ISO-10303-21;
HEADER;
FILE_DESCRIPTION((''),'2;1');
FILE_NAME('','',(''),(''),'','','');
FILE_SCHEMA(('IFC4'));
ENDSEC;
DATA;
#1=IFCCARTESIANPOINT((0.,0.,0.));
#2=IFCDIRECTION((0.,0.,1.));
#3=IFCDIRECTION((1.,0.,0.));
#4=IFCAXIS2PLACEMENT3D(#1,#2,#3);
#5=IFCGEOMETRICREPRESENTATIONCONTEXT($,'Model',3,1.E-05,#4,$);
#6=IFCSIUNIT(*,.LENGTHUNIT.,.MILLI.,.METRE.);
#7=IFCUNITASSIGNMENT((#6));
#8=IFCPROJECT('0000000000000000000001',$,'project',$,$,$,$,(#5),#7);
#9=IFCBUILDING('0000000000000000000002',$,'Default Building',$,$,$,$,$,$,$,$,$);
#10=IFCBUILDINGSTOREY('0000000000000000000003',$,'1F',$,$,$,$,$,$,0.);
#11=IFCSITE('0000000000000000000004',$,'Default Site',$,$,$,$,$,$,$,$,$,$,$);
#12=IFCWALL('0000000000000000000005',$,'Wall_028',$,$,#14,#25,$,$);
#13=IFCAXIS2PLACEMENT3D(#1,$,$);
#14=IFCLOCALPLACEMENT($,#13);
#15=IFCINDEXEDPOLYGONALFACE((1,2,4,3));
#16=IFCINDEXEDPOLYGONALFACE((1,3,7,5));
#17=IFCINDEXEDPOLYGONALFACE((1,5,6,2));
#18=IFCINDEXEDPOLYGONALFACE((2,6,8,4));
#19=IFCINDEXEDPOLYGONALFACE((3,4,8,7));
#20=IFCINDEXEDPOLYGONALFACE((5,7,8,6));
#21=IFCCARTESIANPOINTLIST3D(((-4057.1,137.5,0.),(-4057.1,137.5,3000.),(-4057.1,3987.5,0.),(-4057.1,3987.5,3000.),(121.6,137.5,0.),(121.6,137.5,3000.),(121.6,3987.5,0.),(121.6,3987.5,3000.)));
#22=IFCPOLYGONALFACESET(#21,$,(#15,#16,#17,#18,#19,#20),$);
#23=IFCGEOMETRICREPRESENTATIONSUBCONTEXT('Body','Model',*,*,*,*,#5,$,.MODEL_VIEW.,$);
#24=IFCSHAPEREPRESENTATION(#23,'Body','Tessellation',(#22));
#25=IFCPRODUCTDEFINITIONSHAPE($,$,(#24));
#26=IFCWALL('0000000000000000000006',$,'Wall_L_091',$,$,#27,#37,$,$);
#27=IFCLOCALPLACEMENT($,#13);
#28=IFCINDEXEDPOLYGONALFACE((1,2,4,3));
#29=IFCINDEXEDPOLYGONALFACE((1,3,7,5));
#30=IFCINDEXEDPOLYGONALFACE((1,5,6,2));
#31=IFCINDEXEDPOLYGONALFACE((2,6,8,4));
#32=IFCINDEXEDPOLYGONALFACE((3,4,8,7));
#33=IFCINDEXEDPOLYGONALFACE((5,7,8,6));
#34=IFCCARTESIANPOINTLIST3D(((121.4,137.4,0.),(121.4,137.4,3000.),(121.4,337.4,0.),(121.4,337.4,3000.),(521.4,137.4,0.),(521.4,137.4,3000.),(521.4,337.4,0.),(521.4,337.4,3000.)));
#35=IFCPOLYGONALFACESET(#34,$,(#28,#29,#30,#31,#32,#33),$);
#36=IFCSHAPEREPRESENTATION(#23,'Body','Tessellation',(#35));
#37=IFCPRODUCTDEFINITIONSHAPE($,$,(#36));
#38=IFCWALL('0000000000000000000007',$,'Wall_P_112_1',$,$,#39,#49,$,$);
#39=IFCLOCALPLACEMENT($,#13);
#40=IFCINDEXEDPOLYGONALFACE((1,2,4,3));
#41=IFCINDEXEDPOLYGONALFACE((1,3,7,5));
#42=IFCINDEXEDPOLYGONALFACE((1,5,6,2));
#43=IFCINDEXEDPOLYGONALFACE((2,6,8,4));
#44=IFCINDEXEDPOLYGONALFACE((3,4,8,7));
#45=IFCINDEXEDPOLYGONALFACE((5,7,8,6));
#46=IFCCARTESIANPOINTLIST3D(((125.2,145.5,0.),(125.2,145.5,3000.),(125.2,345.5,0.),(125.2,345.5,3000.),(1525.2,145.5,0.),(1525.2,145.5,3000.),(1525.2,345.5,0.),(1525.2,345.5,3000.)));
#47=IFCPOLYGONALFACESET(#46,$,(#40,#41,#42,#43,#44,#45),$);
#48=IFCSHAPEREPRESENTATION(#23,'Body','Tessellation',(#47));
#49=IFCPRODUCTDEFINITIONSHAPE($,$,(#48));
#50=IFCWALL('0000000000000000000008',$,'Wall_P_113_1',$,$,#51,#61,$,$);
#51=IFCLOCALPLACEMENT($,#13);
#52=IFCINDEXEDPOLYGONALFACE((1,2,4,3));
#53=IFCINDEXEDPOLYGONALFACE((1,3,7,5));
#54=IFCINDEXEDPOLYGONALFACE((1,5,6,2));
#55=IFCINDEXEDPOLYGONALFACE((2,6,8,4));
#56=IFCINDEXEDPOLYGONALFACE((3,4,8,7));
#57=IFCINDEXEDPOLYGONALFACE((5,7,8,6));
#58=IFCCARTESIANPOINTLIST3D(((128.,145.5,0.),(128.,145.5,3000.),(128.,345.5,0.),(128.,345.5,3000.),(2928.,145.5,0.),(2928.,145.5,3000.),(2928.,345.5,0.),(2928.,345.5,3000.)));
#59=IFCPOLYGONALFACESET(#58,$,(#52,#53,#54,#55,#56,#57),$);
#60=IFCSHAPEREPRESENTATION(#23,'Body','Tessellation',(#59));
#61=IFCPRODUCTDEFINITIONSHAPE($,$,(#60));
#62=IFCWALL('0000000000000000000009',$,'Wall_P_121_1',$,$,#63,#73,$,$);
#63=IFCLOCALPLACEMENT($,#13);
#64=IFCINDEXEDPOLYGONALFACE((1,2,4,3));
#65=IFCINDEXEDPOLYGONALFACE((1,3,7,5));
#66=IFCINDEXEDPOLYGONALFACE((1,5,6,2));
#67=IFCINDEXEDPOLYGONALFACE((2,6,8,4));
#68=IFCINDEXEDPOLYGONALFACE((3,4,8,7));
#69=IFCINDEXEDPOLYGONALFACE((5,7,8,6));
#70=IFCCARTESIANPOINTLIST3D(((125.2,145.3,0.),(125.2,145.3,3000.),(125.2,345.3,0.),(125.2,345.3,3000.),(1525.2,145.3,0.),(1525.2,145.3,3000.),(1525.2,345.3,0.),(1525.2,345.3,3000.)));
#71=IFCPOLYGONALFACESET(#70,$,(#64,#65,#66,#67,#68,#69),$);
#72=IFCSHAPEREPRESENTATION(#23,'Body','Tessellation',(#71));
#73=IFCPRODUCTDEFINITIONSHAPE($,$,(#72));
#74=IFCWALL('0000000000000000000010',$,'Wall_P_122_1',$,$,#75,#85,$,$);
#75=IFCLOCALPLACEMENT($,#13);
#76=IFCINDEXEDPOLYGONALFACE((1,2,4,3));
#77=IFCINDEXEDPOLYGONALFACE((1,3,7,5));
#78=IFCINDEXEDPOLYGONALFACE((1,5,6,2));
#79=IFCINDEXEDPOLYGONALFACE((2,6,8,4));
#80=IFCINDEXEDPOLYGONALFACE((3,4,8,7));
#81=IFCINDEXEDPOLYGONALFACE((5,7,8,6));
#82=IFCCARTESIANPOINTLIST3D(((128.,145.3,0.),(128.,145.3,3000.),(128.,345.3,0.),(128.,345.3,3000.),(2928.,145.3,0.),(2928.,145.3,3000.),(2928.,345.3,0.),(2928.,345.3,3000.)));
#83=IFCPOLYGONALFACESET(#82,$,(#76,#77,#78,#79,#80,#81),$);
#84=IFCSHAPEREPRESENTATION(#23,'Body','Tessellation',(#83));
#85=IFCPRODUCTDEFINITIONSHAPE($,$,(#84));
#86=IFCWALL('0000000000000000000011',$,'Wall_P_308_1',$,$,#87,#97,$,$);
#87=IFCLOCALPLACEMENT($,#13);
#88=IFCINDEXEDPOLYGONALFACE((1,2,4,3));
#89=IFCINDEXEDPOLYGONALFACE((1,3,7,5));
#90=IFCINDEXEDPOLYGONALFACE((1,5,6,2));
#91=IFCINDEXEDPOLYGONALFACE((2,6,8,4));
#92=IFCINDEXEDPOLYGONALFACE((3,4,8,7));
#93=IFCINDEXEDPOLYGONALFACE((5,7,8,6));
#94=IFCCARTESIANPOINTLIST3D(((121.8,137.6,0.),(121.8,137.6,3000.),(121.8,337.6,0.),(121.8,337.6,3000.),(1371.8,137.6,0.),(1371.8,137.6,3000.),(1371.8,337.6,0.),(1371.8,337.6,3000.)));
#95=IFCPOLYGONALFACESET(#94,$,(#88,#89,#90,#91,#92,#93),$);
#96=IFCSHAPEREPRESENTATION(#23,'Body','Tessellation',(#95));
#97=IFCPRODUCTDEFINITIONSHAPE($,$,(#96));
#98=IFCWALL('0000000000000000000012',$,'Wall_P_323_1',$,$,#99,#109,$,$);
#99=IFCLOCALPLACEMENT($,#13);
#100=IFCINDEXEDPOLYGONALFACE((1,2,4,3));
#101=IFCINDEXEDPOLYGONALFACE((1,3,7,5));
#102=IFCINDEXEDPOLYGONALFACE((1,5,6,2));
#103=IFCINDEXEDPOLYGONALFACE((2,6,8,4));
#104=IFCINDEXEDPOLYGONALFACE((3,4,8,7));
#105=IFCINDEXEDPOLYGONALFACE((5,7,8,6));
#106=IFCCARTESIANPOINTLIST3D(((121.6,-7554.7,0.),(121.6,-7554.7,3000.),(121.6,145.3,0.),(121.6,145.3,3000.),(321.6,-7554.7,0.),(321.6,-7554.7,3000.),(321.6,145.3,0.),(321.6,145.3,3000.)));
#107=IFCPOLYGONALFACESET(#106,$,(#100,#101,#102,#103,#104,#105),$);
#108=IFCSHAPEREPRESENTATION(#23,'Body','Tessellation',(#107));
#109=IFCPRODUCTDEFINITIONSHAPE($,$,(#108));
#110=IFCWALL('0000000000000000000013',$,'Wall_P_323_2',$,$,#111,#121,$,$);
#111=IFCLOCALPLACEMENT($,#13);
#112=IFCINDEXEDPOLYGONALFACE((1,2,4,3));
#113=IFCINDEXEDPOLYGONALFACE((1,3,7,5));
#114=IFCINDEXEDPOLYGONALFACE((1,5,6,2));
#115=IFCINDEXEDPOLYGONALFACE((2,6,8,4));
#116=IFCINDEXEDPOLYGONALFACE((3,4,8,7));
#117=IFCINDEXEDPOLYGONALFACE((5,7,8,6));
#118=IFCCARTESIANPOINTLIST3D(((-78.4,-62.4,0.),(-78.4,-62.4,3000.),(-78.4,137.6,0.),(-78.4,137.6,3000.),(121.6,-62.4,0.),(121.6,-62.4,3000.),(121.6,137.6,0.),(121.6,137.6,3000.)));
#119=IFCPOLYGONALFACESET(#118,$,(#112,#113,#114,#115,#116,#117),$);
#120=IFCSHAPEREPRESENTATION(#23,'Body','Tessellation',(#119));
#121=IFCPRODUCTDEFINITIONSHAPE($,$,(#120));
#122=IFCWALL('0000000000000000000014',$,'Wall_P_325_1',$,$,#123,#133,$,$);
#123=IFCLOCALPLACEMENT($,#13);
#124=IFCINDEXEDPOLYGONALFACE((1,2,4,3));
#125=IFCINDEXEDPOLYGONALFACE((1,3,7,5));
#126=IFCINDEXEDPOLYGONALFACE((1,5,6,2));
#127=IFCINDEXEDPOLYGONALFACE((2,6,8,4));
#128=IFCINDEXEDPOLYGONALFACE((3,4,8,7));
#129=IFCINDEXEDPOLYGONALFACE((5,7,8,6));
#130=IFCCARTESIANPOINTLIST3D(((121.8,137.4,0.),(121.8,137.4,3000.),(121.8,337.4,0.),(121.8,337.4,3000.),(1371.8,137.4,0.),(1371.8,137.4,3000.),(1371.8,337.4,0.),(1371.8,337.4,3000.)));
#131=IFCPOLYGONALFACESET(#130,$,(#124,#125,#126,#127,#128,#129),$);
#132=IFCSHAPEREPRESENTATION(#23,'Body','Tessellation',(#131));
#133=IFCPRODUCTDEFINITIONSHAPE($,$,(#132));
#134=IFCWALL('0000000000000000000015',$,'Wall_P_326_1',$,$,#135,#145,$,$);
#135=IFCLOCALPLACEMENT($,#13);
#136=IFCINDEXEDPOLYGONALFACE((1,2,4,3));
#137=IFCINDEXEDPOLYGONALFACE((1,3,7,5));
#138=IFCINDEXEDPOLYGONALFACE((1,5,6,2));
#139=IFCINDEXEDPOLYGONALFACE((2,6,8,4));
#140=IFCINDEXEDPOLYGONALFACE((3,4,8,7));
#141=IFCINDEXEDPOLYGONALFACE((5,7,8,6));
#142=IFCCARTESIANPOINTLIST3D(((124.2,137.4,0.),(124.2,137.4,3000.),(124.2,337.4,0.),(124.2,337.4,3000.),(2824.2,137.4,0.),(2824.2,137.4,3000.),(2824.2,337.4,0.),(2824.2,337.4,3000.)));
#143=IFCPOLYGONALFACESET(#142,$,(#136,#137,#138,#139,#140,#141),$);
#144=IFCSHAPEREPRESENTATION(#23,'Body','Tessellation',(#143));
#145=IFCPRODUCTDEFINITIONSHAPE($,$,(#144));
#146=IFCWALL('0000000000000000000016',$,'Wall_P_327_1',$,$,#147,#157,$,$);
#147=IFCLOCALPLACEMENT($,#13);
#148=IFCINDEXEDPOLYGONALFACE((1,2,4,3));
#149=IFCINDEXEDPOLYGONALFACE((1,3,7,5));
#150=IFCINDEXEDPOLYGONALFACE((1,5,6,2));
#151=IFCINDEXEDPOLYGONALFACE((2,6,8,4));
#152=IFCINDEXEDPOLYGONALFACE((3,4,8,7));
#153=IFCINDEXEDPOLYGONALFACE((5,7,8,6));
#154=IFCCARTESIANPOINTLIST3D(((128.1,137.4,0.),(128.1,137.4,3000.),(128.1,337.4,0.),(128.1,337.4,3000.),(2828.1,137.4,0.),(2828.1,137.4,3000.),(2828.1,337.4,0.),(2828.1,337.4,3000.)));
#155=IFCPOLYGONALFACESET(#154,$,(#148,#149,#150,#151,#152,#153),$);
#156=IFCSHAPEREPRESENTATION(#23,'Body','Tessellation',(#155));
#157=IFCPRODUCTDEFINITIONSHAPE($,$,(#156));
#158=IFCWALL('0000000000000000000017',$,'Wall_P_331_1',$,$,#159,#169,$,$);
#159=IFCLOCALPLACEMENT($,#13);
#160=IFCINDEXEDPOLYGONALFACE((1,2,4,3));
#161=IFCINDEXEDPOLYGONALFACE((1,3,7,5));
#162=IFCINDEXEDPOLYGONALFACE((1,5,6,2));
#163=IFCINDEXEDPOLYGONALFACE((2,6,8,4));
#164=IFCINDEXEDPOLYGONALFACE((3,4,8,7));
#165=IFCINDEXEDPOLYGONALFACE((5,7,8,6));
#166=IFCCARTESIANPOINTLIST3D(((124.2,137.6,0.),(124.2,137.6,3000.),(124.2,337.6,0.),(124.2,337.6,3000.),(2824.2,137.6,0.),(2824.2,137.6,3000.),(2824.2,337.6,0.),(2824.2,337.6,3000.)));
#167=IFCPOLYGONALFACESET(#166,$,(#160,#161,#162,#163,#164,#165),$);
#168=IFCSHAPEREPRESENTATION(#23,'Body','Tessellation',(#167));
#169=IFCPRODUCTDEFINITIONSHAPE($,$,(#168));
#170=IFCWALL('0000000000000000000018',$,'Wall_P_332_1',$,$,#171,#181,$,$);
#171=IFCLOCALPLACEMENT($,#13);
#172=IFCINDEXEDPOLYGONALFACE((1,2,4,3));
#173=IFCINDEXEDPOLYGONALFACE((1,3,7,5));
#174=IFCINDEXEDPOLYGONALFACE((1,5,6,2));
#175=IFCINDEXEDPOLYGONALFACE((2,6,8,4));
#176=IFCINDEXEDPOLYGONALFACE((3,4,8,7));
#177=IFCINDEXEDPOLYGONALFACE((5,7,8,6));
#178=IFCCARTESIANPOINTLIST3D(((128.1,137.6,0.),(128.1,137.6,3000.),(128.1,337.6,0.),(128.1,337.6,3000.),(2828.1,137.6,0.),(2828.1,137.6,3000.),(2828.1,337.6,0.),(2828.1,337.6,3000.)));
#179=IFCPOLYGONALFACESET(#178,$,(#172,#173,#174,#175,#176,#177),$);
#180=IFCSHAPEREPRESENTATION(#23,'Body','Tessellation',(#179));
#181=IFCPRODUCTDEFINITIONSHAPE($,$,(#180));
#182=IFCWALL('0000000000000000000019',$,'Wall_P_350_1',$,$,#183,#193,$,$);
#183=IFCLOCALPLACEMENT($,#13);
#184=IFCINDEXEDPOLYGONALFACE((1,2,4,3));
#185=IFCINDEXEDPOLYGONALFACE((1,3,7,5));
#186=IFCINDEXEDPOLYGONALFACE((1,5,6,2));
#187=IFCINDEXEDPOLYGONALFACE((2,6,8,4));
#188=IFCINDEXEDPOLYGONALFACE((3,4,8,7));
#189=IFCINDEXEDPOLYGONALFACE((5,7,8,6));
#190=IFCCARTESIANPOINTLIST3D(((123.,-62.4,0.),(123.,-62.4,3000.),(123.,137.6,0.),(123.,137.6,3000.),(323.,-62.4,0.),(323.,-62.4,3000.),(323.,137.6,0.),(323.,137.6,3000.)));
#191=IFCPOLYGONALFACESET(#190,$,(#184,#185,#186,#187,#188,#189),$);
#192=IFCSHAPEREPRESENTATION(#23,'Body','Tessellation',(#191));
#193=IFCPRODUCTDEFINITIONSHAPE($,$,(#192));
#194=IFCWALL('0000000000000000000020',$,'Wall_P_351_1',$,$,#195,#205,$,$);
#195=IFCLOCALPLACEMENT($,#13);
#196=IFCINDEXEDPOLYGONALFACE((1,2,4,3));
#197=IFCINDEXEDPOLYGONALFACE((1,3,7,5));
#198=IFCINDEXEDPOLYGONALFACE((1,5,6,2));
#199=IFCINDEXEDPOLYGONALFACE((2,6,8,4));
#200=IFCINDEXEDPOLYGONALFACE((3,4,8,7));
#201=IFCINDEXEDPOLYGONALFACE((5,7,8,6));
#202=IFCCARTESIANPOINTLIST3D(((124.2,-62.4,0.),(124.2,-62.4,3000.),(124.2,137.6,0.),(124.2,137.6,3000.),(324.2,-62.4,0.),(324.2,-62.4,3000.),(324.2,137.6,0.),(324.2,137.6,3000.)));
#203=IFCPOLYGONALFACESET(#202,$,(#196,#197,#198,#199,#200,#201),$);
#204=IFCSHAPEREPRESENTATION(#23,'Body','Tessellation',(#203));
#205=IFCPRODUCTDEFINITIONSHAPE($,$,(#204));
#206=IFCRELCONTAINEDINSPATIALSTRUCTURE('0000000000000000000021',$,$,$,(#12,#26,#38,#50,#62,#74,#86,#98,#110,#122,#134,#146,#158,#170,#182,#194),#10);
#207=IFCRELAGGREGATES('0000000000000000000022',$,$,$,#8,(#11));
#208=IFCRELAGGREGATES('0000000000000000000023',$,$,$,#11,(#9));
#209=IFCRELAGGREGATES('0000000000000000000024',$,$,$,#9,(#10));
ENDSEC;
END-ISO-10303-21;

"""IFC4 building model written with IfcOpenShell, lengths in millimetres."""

from ifc_helpers import new_model, si_unit, frame, origin_with_axes, place, context, subcontext, project, spatial, indexed_curve, outline, extrude, element, save


model = new_model("IFC4")

# Units and contexts
model_context = context("Model", 3, precision=1e-05, world=origin_with_axes())
body_context = subcontext(model_context, "Body", "Model", "MODEL_VIEW")
ifc_project = project(units=[si_unit("LENGTHUNIT", "METRE", prefix="MILLI")], contexts=[model_context])

# Site, building, storey
site = spatial("IfcSite", under=ifc_project, Name="Default Site")
building = spatial("IfcBuilding", under=site, Name="Default Building")
storey = spatial("IfcBuildingStorey", under=building, Name="1F", Elevation=0.0)

# Walls
wall_1_placement = place(None, frame((121.6, 137.5, 0.0), z_axis=(0.0, 0.0, 1.0), x_axis=(0.0, 1.0, 0.0)))
element("IfcWall", 1, at=wall_1_placement, inside=storey, Name="Wall_028", context=body_context, shape_type="SweptSolid", body=[
    extrude(outline(indexed_curve([(0.0, 0.0), (0.0, 4178.7), (3850.0, 4178.7), (3850.0, 0.0), (0.0, 0.0)], self_intersect=False)), origin_with_axes(), (0.0, 0.0, 1.0), 3000.0),
])
wall_2_placement = place(None, frame((121.4, 137.4, 0.0), z_axis=(0.0, 0.0, 1.0), x_axis=(1.0, 0.0, 0.0)))
element("IfcWall", 2, at=wall_2_placement, inside=storey, Name="Wall_L_091", context=body_context, shape_type="SweptSolid", body=[
    extrude(outline(indexed_curve([(0.0, 0.0), (0.0, 200.0), (400.0, 200.0), (400.0, 0.0), (0.0, 0.0)], self_intersect=False)), origin_with_axes(), (0.0, 0.0, 1.0), 3000.0),
])
wall_3_placement = place(None, frame((125.2, 145.5, 0.0), z_axis=(0.0, 0.0, 1.0), x_axis=(1.0, 0.0, 0.0)))
element("IfcWall", 3, at=wall_3_placement, inside=storey, Name="Wall_P_112_1", context=body_context, shape_type="SweptSolid", body=[
    extrude(outline(indexed_curve([(0.0, 0.0), (0.0, 200.0), (1400.0, 200.0), (1400.0, 0.0), (0.0, 0.0)], self_intersect=False)), origin_with_axes(), (0.0, 0.0, 1.0), 3000.0),
])
wall_4_placement = place(None, frame((128.0, 145.5, 0.0), z_axis=(0.0, 0.0, 1.0), x_axis=(1.0, 0.0, 0.0)))
element("IfcWall", 4, at=wall_4_placement, inside=storey, Name="Wall_P_113_1", context=body_context, shape_type="SweptSolid", body=[
    extrude(outline(indexed_curve([(0.0, 0.0), (0.0, 200.0), (2800.0, 200.0), (2800.0, 0.0), (0.0, 0.0)], self_intersect=False)), origin_with_axes(), (0.0, 0.0, 1.0), 3000.0),
])
wall_5_placement = place(None, frame((125.2, 145.3, 0.0), z_axis=(0.0, 0.0, 1.0), x_axis=(1.0, 0.0, 0.0)))
element("IfcWall", 5, at=wall_5_placement, inside=storey, Name="Wall_P_121_1", context=body_context, shape_type="SweptSolid", body=[
    extrude(outline(indexed_curve([(0.0, 0.0), (0.0, 200.0), (1400.0, 200.0), (1400.0, 0.0), (0.0, 0.0)], self_intersect=False)), origin_with_axes(), (0.0, 0.0, 1.0), 3000.0),
])
wall_6_placement = place(None, frame((128.0, 145.3, 0.0), z_axis=(0.0, 0.0, 1.0), x_axis=(1.0, 0.0, 0.0)))
element("IfcWall", 6, at=wall_6_placement, inside=storey, Name="Wall_P_122_1", context=body_context, shape_type="SweptSolid", body=[
    extrude(outline(indexed_curve([(0.0, 0.0), (0.0, 200.0), (2800.0, 200.0), (2800.0, 0.0), (0.0, 0.0)], self_intersect=False)), origin_with_axes(), (0.0, 0.0, 1.0), 3000.0),
])
wall_7_placement = place(None, frame((121.8, 137.6, 0.0), z_axis=(0.0, 0.0, 1.0), x_axis=(1.0, 0.0, 0.0)))
element("IfcWall", 7, at=wall_7_placement, inside=storey, Name="Wall_P_308_1", context=body_context, shape_type="SweptSolid", body=[
    extrude(outline(indexed_curve([(0.0, 0.0), (0.0, 200.0), (1250.0, 200.0), (1250.0, 0.0), (0.0, 0.0)], self_intersect=False)), origin_with_axes(), (0.0, 0.0, 1.0), 3000.0),
])
wall_8_placement = place(None, frame((121.6, 145.3, 0.0), z_axis=(0.0, 0.0, 1.0), x_axis=(0.0, -1.0, 0.0)))
element("IfcWall", 8, at=wall_8_placement, inside=storey, Name="Wall_P_323_1", context=body_context, shape_type="SweptSolid", body=[
    extrude(outline(indexed_curve([(0.0, 0.0), (0.0, 200.0), (7700.0, 200.0), (7700.0, 0.0), (0.0, 0.0)], self_intersect=False)), origin_with_axes(), (0.0, 0.0, 1.0), 3000.0),
])
wall_9_placement = place(None, frame((121.6, 137.6, 0.0), z_axis=(0.0, 0.0, 1.0), x_axis=(-1.0, 0.0, 0.0)))
element("IfcWall", 9, at=wall_9_placement, inside=storey, Name="Wall_P_323_2", context=body_context, shape_type="SweptSolid", body=[
    extrude(outline(indexed_curve([(0.0, 0.0), (0.0, 200.0), (200.0, 200.0), (200.0, 0.0), (0.0, 0.0)], self_intersect=False)), origin_with_axes(), (0.0, 0.0, 1.0), 3000.0),
])
wall_10_placement = place(None, frame((121.8, 137.4, 0.0), z_axis=(0.0, 0.0, 1.0), x_axis=(1.0, 0.0, 0.0)))
element("IfcWall", 10, at=wall_10_placement, inside=storey, Name="Wall_P_325_1", context=body_context, shape_type="SweptSolid", body=[
    extrude(outline(indexed_curve([(0.0, 0.0), (0.0, 200.0), (1250.0, 200.0), (1250.0, 0.0), (0.0, 0.0)], self_intersect=False)), origin_with_axes(), (0.0, 0.0, 1.0), 3000.0),
])
wall_11_placement = place(None, frame((124.2, 137.4, 0.0), z_axis=(0.0, 0.0, 1.0), x_axis=(1.0, 0.0, 0.0)))
element("IfcWall", 11, at=wall_11_placement, inside=storey, Name="Wall_P_326_1", context=body_context, shape_type="SweptSolid", body=[
    extrude(outline(indexed_curve([(0.0, 0.0), (0.0, 200.0), (2700.0, 200.0), (2700.0, 0.0), (0.0, 0.0)], self_intersect=False)), origin_with_axes(), (0.0, 0.0, 1.0), 3000.0),
])
wall_12_placement = place(None, frame((128.1, 137.4, 0.0), z_axis=(0.0, 0.0, 1.0), x_axis=(1.0, 0.0, 0.0)))
element("IfcWall", 12, at=wall_12_placement, inside=storey, Name="Wall_P_327_1", context=body_context, shape_type="SweptSolid", body=[
    extrude(outline(indexed_curve([(0.0, 0.0), (0.0, 200.0), (2700.0, 200.0), (2700.0, 0.0), (0.0, 0.0)], self_intersect=False)), origin_with_axes(), (0.0, 0.0, 1.0), 3000.0),
])
wall_13_placement = place(None, frame((124.2, 137.6, 0.0), z_axis=(0.0, 0.0, 1.0), x_axis=(1.0, 0.0, 0.0)))
element("IfcWall", 13, at=wall_13_placement, inside=storey, Name="Wall_P_331_1", context=body_context, shape_type="SweptSolid", body=[
    extrude(outline(indexed_curve([(0.0, 0.0), (0.0, 200.0), (2700.0, 200.0), (2700.0, 0.0), (0.0, 0.0)], self_intersect=False)), origin_with_axes(), (0.0, 0.0, 1.0), 3000.0),
])
wall_14_placement = place(None, frame((128.1, 137.6, 0.0), z_axis=(0.0, 0.0, 1.0), x_axis=(1.0, 0.0, 0.0)))
element("IfcWall", 14, at=wall_14_placement, inside=storey, Name="Wall_P_332_1", context=body_context, shape_type="SweptSolid", body=[
    extrude(outline(indexed_curve([(0.0, 0.0), (0.0, 200.0), (2700.0, 200.0), (2700.0, 0.0), (0.0, 0.0)], self_intersect=False)), origin_with_axes(), (0.0, 0.0, 1.0), 3000.0),
])
for number, where, z_axis, x_axis, name in (
    (15, (123.0, 137.6, 0.0), (0.0, 0.0, 1.0), (0.0, -1.0, 0.0), "Wall_P_350_1"),
    (16, (124.2, 137.6, 0.0), (0.0, 0.0, 1.0), (0.0, -1.0, 0.0), "Wall_P_351_1"),
):
    element("IfcWall", number, at=place(None, frame(where, z_axis=z_axis, x_axis=x_axis)), inside=storey, Name=name, context=body_context, shape_type="SweptSolid", body=[
        extrude(outline(indexed_curve([(0.0, 0.0), (0.0, 200.0), (200.0, 200.0), (200.0, 0.0), (0.0, 0.0)], self_intersect=False)), origin_with_axes(), (0.0, 0.0, 1.0), 3000.0),
    ])

save(model, "model.ifc")
